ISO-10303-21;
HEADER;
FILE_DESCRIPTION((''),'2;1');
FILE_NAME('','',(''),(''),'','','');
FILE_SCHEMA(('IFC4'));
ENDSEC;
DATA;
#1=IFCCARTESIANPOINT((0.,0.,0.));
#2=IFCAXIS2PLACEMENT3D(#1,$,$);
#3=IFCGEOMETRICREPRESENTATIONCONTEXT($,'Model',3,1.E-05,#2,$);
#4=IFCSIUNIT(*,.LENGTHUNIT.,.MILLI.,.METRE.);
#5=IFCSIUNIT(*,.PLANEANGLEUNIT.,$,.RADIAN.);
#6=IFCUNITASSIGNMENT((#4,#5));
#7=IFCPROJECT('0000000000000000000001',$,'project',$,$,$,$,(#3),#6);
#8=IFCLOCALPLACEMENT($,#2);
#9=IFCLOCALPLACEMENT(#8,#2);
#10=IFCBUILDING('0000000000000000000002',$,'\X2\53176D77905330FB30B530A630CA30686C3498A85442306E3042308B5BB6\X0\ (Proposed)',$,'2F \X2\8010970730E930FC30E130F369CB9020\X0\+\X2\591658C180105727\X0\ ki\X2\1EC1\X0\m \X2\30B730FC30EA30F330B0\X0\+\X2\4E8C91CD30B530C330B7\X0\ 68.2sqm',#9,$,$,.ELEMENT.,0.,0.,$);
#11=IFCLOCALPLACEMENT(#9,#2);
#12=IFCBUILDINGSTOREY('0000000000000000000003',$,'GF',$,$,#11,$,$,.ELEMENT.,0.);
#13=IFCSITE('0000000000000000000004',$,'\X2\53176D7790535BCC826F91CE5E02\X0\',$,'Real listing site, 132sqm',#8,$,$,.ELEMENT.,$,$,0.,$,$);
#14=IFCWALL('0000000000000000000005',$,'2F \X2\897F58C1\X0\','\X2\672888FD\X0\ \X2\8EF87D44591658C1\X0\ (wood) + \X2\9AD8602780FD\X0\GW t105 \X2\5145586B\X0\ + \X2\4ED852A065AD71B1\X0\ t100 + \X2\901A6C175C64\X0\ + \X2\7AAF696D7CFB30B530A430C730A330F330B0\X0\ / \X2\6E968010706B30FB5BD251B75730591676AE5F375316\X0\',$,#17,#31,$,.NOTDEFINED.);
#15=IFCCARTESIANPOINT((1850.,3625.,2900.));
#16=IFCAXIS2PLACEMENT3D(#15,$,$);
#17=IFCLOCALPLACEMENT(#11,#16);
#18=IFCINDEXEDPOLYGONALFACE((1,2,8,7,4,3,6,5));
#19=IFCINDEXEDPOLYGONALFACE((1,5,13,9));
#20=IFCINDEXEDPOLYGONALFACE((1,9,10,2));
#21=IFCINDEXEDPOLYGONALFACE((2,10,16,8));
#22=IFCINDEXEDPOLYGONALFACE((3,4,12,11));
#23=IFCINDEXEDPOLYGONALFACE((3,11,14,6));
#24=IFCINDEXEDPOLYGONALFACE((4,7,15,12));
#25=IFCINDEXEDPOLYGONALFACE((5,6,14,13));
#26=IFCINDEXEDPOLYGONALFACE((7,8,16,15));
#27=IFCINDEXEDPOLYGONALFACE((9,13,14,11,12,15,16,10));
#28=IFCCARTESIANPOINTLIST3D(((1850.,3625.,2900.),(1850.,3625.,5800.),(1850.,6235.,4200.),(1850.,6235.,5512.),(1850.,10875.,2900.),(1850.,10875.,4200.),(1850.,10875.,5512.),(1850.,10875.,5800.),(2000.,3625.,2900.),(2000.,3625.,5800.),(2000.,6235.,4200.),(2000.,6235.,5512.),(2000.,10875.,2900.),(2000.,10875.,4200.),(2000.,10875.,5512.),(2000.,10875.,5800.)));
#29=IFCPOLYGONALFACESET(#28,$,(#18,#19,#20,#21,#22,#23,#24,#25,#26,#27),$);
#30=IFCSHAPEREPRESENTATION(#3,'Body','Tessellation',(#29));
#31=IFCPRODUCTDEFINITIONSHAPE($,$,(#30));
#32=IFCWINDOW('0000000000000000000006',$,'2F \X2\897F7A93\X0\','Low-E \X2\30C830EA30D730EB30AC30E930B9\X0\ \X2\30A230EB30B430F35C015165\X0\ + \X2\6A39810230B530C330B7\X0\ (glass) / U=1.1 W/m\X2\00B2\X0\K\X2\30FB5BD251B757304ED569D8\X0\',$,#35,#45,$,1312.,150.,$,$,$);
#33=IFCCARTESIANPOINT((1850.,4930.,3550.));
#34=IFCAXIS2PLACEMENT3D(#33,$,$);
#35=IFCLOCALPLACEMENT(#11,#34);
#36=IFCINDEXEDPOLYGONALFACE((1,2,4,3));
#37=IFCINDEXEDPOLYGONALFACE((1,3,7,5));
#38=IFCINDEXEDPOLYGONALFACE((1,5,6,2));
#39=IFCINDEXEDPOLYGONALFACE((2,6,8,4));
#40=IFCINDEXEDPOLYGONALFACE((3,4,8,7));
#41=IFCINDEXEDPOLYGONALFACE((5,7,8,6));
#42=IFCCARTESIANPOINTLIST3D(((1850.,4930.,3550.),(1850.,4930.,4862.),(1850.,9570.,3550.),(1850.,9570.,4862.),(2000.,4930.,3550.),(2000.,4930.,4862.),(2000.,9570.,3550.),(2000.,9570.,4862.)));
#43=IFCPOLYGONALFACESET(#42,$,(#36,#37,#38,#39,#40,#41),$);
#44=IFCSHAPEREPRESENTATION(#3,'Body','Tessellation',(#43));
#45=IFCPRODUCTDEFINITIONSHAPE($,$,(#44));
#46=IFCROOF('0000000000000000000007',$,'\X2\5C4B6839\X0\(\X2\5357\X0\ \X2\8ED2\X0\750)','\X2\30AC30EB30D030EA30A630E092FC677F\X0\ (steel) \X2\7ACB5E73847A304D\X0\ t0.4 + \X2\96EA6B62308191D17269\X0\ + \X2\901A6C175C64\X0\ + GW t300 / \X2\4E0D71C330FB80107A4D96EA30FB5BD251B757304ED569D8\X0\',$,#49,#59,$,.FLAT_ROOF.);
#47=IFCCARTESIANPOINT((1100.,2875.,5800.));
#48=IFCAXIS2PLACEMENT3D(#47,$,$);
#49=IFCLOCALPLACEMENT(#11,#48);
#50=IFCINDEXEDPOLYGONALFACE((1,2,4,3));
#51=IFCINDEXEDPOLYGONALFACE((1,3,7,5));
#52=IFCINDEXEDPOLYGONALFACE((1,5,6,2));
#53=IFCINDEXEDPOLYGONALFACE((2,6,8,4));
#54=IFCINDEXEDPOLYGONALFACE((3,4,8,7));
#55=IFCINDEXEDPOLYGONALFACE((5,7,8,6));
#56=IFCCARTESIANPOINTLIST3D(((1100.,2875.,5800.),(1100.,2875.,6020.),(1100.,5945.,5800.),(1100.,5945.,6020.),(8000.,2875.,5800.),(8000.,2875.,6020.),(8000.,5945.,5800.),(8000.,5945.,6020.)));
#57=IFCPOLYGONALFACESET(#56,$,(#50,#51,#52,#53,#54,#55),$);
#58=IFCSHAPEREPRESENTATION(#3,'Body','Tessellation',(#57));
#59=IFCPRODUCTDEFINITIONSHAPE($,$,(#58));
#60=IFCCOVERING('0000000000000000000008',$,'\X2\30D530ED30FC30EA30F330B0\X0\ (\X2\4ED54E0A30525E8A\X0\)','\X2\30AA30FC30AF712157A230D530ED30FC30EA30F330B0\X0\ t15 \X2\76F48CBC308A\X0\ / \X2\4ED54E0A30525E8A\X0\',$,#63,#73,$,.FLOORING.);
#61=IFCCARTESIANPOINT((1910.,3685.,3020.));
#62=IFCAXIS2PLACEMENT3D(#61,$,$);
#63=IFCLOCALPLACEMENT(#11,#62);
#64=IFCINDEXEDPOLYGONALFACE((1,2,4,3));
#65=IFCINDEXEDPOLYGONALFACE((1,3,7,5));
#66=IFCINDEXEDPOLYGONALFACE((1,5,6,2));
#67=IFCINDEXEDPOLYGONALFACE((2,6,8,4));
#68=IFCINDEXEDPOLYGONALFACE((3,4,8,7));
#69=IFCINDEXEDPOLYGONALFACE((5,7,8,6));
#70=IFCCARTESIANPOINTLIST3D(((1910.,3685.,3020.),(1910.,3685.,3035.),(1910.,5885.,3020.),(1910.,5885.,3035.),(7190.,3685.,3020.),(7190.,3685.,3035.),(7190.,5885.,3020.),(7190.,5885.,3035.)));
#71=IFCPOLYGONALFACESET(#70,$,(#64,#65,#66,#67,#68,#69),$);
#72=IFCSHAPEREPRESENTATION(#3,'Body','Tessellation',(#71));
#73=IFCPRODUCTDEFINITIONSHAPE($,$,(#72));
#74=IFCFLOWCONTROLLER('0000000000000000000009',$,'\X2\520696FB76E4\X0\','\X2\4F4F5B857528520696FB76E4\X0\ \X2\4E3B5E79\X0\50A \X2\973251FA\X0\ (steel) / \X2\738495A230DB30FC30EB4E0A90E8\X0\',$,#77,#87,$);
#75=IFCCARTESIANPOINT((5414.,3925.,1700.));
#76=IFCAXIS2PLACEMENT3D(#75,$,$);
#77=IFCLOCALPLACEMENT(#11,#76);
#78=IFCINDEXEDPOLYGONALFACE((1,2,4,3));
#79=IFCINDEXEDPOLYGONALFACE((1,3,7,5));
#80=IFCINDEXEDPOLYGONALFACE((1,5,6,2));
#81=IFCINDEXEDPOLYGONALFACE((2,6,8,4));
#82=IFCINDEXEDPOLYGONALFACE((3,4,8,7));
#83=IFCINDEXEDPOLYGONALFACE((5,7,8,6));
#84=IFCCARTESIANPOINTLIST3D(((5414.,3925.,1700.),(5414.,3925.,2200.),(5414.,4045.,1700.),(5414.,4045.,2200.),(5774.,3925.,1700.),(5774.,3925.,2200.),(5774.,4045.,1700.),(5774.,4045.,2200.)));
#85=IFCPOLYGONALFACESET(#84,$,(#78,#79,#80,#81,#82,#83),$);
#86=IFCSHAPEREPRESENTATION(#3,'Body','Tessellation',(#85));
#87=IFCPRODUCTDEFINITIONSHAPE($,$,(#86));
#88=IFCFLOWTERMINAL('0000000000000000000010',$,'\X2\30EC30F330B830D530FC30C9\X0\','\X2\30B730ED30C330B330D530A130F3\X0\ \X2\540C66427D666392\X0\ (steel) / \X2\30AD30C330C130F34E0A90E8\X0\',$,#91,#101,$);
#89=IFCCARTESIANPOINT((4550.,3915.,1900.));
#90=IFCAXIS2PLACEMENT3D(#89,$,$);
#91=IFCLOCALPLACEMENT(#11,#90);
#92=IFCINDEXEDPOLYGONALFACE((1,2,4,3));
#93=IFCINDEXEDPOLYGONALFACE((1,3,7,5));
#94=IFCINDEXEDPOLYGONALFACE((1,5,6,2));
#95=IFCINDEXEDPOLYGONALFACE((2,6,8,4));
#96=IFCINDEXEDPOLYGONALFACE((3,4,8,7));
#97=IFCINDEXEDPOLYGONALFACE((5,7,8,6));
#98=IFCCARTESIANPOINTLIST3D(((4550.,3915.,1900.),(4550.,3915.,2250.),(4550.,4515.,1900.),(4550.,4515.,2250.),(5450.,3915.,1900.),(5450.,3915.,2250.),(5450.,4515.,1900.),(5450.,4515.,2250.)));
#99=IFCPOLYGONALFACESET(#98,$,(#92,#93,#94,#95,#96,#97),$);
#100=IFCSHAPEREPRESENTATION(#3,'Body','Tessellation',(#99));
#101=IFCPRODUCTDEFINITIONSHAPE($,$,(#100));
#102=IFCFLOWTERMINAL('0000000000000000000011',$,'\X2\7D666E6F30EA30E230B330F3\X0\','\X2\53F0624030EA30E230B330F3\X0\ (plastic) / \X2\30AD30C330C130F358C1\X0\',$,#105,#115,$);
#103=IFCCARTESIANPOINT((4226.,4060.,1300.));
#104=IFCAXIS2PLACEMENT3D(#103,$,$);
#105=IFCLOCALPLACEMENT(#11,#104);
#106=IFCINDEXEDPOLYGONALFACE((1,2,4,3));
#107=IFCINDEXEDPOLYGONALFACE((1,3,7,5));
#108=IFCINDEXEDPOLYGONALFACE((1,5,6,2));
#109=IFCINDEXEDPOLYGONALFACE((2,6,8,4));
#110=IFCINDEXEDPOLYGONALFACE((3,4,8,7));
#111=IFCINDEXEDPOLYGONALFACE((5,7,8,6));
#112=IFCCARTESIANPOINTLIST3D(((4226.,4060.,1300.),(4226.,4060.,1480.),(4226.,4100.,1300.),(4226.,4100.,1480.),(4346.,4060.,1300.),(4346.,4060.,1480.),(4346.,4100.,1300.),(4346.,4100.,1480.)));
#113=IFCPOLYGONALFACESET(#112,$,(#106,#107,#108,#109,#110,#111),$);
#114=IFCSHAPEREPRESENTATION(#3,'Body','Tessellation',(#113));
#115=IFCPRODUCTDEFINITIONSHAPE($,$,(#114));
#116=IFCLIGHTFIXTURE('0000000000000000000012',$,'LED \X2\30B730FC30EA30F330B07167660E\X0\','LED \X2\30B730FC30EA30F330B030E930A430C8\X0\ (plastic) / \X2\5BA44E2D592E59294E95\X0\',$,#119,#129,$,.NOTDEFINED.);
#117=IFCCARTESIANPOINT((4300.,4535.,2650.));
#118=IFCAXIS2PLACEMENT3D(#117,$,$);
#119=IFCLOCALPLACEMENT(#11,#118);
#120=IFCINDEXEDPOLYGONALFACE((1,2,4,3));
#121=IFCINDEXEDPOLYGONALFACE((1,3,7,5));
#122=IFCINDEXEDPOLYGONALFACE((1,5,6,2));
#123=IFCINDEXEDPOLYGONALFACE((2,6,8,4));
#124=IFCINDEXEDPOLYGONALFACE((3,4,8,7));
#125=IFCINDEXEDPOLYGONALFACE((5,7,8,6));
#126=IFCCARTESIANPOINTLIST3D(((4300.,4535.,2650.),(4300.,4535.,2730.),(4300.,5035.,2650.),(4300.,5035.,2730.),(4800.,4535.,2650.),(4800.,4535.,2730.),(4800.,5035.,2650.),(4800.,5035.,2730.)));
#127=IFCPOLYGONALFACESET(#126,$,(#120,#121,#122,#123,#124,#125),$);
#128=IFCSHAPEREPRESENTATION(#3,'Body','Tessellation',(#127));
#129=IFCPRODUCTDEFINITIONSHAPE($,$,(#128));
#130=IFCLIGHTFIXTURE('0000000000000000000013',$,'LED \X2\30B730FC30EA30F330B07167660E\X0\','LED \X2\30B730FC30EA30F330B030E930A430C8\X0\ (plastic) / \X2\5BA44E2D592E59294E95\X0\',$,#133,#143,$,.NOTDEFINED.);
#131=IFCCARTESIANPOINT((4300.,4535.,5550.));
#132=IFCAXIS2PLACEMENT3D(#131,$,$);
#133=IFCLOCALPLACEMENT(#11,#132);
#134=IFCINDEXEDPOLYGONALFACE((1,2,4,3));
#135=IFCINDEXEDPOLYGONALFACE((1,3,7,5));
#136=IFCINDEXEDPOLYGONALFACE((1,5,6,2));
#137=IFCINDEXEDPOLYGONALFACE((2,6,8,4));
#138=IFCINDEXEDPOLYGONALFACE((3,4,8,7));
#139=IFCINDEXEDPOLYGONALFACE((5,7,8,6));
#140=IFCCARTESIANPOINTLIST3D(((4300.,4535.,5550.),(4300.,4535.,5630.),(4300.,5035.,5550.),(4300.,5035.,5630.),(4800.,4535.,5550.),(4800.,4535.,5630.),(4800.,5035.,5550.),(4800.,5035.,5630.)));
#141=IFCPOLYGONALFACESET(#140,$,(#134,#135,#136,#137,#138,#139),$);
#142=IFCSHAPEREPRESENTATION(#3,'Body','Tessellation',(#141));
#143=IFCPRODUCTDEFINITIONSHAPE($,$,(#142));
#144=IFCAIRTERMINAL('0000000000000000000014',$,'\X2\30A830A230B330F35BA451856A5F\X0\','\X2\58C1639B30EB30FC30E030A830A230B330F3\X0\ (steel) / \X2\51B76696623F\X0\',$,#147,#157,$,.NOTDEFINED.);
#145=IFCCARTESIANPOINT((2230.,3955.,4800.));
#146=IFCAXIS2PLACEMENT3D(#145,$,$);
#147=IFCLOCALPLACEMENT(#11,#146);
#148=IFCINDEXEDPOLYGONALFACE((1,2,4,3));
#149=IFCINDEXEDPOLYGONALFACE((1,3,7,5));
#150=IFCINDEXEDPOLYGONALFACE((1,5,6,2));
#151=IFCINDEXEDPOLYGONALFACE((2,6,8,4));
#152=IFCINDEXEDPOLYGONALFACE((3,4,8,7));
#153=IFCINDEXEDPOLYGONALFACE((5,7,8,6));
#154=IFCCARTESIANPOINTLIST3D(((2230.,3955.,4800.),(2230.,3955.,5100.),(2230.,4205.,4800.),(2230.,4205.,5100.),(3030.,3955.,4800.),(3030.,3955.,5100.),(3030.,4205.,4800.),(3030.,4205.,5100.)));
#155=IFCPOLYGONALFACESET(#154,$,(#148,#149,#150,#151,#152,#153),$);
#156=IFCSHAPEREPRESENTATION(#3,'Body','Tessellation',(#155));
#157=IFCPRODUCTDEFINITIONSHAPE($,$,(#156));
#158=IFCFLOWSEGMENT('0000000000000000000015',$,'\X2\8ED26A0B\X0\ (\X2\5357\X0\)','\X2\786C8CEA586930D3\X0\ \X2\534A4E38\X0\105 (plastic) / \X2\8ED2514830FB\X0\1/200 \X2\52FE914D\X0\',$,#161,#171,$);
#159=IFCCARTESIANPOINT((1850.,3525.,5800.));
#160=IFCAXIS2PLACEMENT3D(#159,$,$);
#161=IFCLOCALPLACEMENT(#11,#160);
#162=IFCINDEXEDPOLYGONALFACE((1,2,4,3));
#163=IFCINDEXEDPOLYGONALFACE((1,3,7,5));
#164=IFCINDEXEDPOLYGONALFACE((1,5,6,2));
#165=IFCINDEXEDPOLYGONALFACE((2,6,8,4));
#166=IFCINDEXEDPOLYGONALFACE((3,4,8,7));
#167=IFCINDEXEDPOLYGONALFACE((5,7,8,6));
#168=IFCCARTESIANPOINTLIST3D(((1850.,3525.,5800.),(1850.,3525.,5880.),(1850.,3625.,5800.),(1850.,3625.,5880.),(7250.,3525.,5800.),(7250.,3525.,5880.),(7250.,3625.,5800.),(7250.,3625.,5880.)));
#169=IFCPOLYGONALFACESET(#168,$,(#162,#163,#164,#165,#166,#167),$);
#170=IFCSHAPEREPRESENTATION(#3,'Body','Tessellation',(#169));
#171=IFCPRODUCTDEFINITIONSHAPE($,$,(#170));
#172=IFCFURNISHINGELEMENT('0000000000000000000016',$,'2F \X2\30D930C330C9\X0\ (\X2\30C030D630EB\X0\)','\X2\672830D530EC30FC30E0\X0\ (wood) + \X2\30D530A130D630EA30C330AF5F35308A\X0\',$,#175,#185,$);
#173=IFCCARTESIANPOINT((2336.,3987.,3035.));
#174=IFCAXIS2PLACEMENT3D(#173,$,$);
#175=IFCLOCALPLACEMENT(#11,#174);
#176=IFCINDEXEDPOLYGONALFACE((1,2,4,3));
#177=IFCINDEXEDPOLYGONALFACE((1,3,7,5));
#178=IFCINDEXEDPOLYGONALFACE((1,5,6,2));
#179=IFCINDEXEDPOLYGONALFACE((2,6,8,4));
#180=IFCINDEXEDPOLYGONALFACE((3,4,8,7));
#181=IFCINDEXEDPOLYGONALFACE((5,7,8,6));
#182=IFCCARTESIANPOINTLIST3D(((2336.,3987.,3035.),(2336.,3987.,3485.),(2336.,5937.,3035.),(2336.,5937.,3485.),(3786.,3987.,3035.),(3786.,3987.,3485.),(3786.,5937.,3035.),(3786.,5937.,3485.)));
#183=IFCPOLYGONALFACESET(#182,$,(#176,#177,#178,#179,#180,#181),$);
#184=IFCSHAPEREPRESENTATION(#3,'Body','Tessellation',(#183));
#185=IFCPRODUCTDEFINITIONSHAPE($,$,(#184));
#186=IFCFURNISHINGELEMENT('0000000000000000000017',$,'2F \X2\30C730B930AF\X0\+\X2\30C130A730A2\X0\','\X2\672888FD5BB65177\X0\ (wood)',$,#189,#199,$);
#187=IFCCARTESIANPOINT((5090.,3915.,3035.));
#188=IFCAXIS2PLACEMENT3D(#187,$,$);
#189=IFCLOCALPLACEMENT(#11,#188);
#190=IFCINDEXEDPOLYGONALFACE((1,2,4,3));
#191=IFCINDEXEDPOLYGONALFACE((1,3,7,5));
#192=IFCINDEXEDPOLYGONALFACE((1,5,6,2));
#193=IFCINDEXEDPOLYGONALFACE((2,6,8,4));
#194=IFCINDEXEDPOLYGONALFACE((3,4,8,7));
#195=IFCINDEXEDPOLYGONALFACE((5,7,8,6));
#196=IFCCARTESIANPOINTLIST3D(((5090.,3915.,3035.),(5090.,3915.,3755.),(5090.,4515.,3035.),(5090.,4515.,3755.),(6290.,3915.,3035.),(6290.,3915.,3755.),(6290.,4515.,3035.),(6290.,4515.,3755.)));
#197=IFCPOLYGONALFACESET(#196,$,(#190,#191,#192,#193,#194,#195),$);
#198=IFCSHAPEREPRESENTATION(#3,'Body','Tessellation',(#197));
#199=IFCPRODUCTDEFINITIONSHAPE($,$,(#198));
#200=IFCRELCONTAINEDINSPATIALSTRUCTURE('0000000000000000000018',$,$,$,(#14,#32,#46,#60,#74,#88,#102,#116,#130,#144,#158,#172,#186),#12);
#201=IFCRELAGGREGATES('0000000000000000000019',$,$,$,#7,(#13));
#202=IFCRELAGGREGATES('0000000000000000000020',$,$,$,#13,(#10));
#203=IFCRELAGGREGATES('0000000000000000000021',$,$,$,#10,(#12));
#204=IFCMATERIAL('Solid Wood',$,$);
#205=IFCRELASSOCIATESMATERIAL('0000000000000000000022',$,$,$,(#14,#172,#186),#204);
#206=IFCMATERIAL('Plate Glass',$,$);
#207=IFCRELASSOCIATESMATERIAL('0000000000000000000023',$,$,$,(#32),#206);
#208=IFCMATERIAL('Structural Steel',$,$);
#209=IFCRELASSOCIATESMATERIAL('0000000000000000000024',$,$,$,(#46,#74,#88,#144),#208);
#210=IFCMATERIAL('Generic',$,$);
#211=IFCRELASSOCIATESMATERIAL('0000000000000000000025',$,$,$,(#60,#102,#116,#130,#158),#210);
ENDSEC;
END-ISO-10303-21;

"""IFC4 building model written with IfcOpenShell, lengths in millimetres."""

from ifc_helpers import new_model, si_unit, frame, frame_2d, origin, place, context, project, spatial, rectangle, extrude, material, element, fill, save


model = new_model("IFC4")

# Units and contexts
model_context = context("Model", 3, precision=1e-05, world=origin())
ifc_project = project(units=[si_unit("LENGTHUNIT", "METRE", prefix="MILLI"), si_unit("PLANEANGLEUNIT", "RADIAN")], contexts=[model_context])

# Site, building, storey
site_placement = place(None, origin())
site = spatial("IfcSite", under=ifc_project, at=site_placement, Name="北海道富良野市", ObjectType="Real listing site, 132sqm", CompositionType="ELEMENT", RefElevation=0.0)
building_placement = place(site_placement, origin())
building = spatial("IfcBuilding", under=site, at=building_placement, Name="北海道・サウナと水風呂のある家 (Proposed)", ObjectType="2F 耐震ラーメン構造+外壁耐圧 kiềm シーリング+二重サッシ 68.2sqm", CompositionType="ELEMENT", ElevationOfRefHeight=0.0, ElevationOfTerrain=0.0)
storey_placement = place(building_placement, origin())
storey = spatial("IfcBuildingStorey", under=building, at=storey_placement, Name="GF", CompositionType="ELEMENT", Elevation=0.0)

# Shared definitions
ifc_material_1 = material(Name="Solid Wood")

# Wall, opening, window
ifc_material_2 = material(Name="Plate Glass")
wall_1_placement = place(storey_placement, frame((1850.0, 3625.0, 2900.0)))
wall_1 = element("IfcWall", 1, at=wall_1_placement, inside=storey, material=ifc_material_1, Name="2F 西壁", Description="木製 軸組外壁 (wood) + 高性能GW t105 充填 + 付加断熱 t100 + 通気層 + 窯業系サイディング / 準耐火・寒冷地外皮強化", PredefinedType="NOTDEFINED", context=model_context, shape_type="SweptSolid", body=[
    extrude(rectangle(XDim=150.0, YDim=7250.0, at=frame_2d((75.0, 3625.0))), frame((1850.0, 3625.0, 2900.0)), (0.0, 0.0, 1.0), 2900.0),
])
opening_1_placement = place(storey_placement, frame((1850.0, 4930.0, 3550.0)))
opening_1 = element("IfcOpeningElement", 2, at=opening_1_placement, cuts=wall_1, PredefinedType="NOTDEFINED", context=model_context, shape_type="SweptSolid", body=[
    extrude(rectangle(XDim=150.0, YDim=4640.0, at=frame_2d((75.0, 2320.0))), frame((1850.0, 4930.0, 3550.0)), (0.0, 0.0, 1.0), 1312.0),
])
window_1_placement = place(storey_placement, frame((1850.0, 4930.0, 3550.0)))
window_1 = element("IfcWindow", 3, at=window_1_placement, inside=storey, material=ifc_material_2, Name="2F 西窓", Description="Low-E トリプルガラス アルゴン封入 + 樹脂サッシ (glass) / U=1.1 W/m²K・寒冷地仕様", OverallHeight=1312.0, OverallWidth=150.0, context=model_context, shape_type="SweptSolid", body=[
    extrude(rectangle(XDim=150.0, YDim=4640.0, at=frame_2d((75.0, 2320.0))), frame((1850.0, 4930.0, 3550.0)), (0.0, 0.0, 1.0), 1312.0),
])
fill(opening_1, window_1)

# Roof
ifc_material_3 = material(Name="Structural Steel")
for number, where, name in (
    (4, (1100.0, 2875.0, 5800.0), "屋根(南 軒750)"),
):
    element("IfcRoof", number, at=place(storey_placement, frame(where)), inside=storey, material=ifc_material_3, Name=name, Description="ガルバリウム鋼板 (steel) 立平葺き t0.4 + 雪止め金物 + 通気層 + GW t300 / 不燃・耐積雪・寒冷地仕様", PredefinedType="FLAT_ROOF", context=model_context, shape_type="SweptSolid", body=[
        extrude(rectangle(XDim=6900.0, YDim=3070.0, at=frame_2d((3450.0, 1535.0))), frame((1100.0, 2875.0, 5800.0)), (0.0, 0.0, 1.0), 220.0),
    ])

# Covering
ifc_material_4 = material(Name="Generic")
covering_placement = place(storey_placement, frame((1910.0, 3685.0, 3020.0)))
element("IfcCovering", 5, at=covering_placement, inside=storey, material=ifc_material_4, Name="フローリング (仕上げ床)", Description="オーク無垢フローリング t15 直貼り / 仕上げ床", PredefinedType="FLOORING", context=model_context, shape_type="SweptSolid", body=[
    extrude(rectangle(XDim=5280.0, YDim=2200.0, at=frame_2d((2640.0, 1100.0))), frame((1910.0, 3685.0, 3020.0)), (0.0, 0.0, 1.0), 15.0),
])

# Flow controller
flow_controller_placement = place(storey_placement, frame((5414.0, 3925.0, 1700.0)))
element("IfcFlowController", 6, at=flow_controller_placement, inside=storey, material=ifc_material_3, Name="分電盤", Description="住宅用分電盤 主幹50A 露出 (steel) / 玄関ホール上部", context=model_context, shape_type="SweptSolid", body=[
    extrude(rectangle(XDim=360.0, YDim=120.0, at=frame_2d((180.0, 60.0))), frame((5414.0, 3925.0, 1700.0)), (0.0, 0.0, 1.0), 500.0),
])

# Flow terminals
flow_terminal_1_placement = place(storey_placement, frame((4550.0, 3915.0, 1900.0)))
element("IfcFlowTerminal", 7, at=flow_terminal_1_placement, inside=storey, material=ifc_material_3, Name="レンジフード", Description="シロッコファン 同時給排 (steel) / キッチン上部", context=model_context, shape_type="SweptSolid", body=[
    extrude(rectangle(XDim=900.0, YDim=600.0, at=frame_2d((450.0, 300.0))), frame((4550.0, 3915.0, 1900.0)), (0.0, 0.0, 1.0), 350.0),
])
flow_terminal_2_placement = place(storey_placement, frame((4226.0, 4060.0, 1300.0)))
element("IfcFlowTerminal", 8, at=flow_terminal_2_placement, inside=storey, material=ifc_material_4, Name="給湯リモコン", Description="台所リモコン (plastic) / キッチン壁", context=model_context, shape_type="SweptSolid", body=[
    extrude(rectangle(XDim=120.0, YDim=40.0, at=frame_2d((60.0, 20.0))), frame((4226.0, 4060.0, 1300.0)), (0.0, 0.0, 1.0), 180.0),
])

# Light fixtures
light_fixture_1_placement = place(storey_placement, frame((4300.0, 4535.0, 2650.0)))
element("IfcLightFixture", 9, at=light_fixture_1_placement, inside=storey, material=ifc_material_4, Name="LED シーリング照明", Description="LED シーリングライト (plastic) / 室中央天井", PredefinedType="NOTDEFINED", context=model_context, shape_type="SweptSolid", body=[
    extrude(rectangle(XDim=500.0, YDim=500.0, at=frame_2d((250.0, 250.0))), frame((4300.0, 4535.0, 2650.0)), (0.0, 0.0, 1.0), 80.0),
])
light_fixture_2_placement = place(storey_placement, frame((4300.0, 4535.0, 5550.0)))
element("IfcLightFixture", 10, at=light_fixture_2_placement, inside=storey, material=ifc_material_4, Name="LED シーリング照明", Description="LED シーリングライト (plastic) / 室中央天井", PredefinedType="NOTDEFINED", context=model_context, shape_type="SweptSolid", body=[
    extrude(rectangle(XDim=500.0, YDim=500.0, at=frame_2d((250.0, 250.0))), frame((4300.0, 4535.0, 5550.0)), (0.0, 0.0, 1.0), 80.0),
])

# Air terminal
air_terminal_placement = place(storey_placement, frame((2230.0, 3955.0, 4800.0)))
element("IfcAirTerminal", 11, at=air_terminal_placement, inside=storey, material=ifc_material_3, Name="エアコン室内機", Description="壁掛ルームエアコン (steel) / 冷暖房", PredefinedType="NOTDEFINED", context=model_context, shape_type="SweptSolid", body=[
    extrude(rectangle(XDim=800.0, YDim=250.0, at=frame_2d((400.0, 125.0))), frame((2230.0, 3955.0, 4800.0)), (0.0, 0.0, 1.0), 300.0),
])

# Flow segment
flow_segment_placement = place(storey_placement, frame((1850.0, 3525.0, 5800.0)))
element("IfcFlowSegment", 12, at=flow_segment_placement, inside=storey, material=ifc_material_4, Name="軒樋 (南)", Description="硬質塩ビ 半丸105 (plastic) / 軒先・1/200 勾配", context=model_context, shape_type="SweptSolid", body=[
    extrude(rectangle(XDim=5400.0, YDim=100.0, at=frame_2d((2700.0, 50.0))), frame((1850.0, 3525.0, 5800.0)), (0.0, 0.0, 1.0), 80.0),
])

# Furnishing elements
furnishing_1_placement = place(storey_placement, frame((2336.0, 3987.0, 3035.0)))
element("IfcFurnishingElement", 13, at=furnishing_1_placement, inside=storey, material=ifc_material_1, Name="2F ベッド (ダブル)", Description="木フレーム (wood) + ファブリック張り", context=model_context, shape_type="SweptSolid", body=[
    extrude(rectangle(XDim=1450.0, YDim=1950.0, at=frame_2d((725.0, 975.0))), frame((2336.0, 3987.0, 3035.0)), (0.0, 0.0, 1.0), 450.0),
])
furnishing_2_placement = place(storey_placement, frame((5090.0, 3915.0, 3035.0)))
element("IfcFurnishingElement", 14, at=furnishing_2_placement, inside=storey, material=ifc_material_1, Name="2F デスク+チェア", Description="木製家具 (wood)", context=model_context, shape_type="SweptSolid", body=[
    extrude(rectangle(XDim=1200.0, YDim=600.0, at=frame_2d((600.0, 300.0))), frame((5090.0, 3915.0, 3035.0)), (0.0, 0.0, 1.0), 720.0),
])

save(model, "model.ifc")
